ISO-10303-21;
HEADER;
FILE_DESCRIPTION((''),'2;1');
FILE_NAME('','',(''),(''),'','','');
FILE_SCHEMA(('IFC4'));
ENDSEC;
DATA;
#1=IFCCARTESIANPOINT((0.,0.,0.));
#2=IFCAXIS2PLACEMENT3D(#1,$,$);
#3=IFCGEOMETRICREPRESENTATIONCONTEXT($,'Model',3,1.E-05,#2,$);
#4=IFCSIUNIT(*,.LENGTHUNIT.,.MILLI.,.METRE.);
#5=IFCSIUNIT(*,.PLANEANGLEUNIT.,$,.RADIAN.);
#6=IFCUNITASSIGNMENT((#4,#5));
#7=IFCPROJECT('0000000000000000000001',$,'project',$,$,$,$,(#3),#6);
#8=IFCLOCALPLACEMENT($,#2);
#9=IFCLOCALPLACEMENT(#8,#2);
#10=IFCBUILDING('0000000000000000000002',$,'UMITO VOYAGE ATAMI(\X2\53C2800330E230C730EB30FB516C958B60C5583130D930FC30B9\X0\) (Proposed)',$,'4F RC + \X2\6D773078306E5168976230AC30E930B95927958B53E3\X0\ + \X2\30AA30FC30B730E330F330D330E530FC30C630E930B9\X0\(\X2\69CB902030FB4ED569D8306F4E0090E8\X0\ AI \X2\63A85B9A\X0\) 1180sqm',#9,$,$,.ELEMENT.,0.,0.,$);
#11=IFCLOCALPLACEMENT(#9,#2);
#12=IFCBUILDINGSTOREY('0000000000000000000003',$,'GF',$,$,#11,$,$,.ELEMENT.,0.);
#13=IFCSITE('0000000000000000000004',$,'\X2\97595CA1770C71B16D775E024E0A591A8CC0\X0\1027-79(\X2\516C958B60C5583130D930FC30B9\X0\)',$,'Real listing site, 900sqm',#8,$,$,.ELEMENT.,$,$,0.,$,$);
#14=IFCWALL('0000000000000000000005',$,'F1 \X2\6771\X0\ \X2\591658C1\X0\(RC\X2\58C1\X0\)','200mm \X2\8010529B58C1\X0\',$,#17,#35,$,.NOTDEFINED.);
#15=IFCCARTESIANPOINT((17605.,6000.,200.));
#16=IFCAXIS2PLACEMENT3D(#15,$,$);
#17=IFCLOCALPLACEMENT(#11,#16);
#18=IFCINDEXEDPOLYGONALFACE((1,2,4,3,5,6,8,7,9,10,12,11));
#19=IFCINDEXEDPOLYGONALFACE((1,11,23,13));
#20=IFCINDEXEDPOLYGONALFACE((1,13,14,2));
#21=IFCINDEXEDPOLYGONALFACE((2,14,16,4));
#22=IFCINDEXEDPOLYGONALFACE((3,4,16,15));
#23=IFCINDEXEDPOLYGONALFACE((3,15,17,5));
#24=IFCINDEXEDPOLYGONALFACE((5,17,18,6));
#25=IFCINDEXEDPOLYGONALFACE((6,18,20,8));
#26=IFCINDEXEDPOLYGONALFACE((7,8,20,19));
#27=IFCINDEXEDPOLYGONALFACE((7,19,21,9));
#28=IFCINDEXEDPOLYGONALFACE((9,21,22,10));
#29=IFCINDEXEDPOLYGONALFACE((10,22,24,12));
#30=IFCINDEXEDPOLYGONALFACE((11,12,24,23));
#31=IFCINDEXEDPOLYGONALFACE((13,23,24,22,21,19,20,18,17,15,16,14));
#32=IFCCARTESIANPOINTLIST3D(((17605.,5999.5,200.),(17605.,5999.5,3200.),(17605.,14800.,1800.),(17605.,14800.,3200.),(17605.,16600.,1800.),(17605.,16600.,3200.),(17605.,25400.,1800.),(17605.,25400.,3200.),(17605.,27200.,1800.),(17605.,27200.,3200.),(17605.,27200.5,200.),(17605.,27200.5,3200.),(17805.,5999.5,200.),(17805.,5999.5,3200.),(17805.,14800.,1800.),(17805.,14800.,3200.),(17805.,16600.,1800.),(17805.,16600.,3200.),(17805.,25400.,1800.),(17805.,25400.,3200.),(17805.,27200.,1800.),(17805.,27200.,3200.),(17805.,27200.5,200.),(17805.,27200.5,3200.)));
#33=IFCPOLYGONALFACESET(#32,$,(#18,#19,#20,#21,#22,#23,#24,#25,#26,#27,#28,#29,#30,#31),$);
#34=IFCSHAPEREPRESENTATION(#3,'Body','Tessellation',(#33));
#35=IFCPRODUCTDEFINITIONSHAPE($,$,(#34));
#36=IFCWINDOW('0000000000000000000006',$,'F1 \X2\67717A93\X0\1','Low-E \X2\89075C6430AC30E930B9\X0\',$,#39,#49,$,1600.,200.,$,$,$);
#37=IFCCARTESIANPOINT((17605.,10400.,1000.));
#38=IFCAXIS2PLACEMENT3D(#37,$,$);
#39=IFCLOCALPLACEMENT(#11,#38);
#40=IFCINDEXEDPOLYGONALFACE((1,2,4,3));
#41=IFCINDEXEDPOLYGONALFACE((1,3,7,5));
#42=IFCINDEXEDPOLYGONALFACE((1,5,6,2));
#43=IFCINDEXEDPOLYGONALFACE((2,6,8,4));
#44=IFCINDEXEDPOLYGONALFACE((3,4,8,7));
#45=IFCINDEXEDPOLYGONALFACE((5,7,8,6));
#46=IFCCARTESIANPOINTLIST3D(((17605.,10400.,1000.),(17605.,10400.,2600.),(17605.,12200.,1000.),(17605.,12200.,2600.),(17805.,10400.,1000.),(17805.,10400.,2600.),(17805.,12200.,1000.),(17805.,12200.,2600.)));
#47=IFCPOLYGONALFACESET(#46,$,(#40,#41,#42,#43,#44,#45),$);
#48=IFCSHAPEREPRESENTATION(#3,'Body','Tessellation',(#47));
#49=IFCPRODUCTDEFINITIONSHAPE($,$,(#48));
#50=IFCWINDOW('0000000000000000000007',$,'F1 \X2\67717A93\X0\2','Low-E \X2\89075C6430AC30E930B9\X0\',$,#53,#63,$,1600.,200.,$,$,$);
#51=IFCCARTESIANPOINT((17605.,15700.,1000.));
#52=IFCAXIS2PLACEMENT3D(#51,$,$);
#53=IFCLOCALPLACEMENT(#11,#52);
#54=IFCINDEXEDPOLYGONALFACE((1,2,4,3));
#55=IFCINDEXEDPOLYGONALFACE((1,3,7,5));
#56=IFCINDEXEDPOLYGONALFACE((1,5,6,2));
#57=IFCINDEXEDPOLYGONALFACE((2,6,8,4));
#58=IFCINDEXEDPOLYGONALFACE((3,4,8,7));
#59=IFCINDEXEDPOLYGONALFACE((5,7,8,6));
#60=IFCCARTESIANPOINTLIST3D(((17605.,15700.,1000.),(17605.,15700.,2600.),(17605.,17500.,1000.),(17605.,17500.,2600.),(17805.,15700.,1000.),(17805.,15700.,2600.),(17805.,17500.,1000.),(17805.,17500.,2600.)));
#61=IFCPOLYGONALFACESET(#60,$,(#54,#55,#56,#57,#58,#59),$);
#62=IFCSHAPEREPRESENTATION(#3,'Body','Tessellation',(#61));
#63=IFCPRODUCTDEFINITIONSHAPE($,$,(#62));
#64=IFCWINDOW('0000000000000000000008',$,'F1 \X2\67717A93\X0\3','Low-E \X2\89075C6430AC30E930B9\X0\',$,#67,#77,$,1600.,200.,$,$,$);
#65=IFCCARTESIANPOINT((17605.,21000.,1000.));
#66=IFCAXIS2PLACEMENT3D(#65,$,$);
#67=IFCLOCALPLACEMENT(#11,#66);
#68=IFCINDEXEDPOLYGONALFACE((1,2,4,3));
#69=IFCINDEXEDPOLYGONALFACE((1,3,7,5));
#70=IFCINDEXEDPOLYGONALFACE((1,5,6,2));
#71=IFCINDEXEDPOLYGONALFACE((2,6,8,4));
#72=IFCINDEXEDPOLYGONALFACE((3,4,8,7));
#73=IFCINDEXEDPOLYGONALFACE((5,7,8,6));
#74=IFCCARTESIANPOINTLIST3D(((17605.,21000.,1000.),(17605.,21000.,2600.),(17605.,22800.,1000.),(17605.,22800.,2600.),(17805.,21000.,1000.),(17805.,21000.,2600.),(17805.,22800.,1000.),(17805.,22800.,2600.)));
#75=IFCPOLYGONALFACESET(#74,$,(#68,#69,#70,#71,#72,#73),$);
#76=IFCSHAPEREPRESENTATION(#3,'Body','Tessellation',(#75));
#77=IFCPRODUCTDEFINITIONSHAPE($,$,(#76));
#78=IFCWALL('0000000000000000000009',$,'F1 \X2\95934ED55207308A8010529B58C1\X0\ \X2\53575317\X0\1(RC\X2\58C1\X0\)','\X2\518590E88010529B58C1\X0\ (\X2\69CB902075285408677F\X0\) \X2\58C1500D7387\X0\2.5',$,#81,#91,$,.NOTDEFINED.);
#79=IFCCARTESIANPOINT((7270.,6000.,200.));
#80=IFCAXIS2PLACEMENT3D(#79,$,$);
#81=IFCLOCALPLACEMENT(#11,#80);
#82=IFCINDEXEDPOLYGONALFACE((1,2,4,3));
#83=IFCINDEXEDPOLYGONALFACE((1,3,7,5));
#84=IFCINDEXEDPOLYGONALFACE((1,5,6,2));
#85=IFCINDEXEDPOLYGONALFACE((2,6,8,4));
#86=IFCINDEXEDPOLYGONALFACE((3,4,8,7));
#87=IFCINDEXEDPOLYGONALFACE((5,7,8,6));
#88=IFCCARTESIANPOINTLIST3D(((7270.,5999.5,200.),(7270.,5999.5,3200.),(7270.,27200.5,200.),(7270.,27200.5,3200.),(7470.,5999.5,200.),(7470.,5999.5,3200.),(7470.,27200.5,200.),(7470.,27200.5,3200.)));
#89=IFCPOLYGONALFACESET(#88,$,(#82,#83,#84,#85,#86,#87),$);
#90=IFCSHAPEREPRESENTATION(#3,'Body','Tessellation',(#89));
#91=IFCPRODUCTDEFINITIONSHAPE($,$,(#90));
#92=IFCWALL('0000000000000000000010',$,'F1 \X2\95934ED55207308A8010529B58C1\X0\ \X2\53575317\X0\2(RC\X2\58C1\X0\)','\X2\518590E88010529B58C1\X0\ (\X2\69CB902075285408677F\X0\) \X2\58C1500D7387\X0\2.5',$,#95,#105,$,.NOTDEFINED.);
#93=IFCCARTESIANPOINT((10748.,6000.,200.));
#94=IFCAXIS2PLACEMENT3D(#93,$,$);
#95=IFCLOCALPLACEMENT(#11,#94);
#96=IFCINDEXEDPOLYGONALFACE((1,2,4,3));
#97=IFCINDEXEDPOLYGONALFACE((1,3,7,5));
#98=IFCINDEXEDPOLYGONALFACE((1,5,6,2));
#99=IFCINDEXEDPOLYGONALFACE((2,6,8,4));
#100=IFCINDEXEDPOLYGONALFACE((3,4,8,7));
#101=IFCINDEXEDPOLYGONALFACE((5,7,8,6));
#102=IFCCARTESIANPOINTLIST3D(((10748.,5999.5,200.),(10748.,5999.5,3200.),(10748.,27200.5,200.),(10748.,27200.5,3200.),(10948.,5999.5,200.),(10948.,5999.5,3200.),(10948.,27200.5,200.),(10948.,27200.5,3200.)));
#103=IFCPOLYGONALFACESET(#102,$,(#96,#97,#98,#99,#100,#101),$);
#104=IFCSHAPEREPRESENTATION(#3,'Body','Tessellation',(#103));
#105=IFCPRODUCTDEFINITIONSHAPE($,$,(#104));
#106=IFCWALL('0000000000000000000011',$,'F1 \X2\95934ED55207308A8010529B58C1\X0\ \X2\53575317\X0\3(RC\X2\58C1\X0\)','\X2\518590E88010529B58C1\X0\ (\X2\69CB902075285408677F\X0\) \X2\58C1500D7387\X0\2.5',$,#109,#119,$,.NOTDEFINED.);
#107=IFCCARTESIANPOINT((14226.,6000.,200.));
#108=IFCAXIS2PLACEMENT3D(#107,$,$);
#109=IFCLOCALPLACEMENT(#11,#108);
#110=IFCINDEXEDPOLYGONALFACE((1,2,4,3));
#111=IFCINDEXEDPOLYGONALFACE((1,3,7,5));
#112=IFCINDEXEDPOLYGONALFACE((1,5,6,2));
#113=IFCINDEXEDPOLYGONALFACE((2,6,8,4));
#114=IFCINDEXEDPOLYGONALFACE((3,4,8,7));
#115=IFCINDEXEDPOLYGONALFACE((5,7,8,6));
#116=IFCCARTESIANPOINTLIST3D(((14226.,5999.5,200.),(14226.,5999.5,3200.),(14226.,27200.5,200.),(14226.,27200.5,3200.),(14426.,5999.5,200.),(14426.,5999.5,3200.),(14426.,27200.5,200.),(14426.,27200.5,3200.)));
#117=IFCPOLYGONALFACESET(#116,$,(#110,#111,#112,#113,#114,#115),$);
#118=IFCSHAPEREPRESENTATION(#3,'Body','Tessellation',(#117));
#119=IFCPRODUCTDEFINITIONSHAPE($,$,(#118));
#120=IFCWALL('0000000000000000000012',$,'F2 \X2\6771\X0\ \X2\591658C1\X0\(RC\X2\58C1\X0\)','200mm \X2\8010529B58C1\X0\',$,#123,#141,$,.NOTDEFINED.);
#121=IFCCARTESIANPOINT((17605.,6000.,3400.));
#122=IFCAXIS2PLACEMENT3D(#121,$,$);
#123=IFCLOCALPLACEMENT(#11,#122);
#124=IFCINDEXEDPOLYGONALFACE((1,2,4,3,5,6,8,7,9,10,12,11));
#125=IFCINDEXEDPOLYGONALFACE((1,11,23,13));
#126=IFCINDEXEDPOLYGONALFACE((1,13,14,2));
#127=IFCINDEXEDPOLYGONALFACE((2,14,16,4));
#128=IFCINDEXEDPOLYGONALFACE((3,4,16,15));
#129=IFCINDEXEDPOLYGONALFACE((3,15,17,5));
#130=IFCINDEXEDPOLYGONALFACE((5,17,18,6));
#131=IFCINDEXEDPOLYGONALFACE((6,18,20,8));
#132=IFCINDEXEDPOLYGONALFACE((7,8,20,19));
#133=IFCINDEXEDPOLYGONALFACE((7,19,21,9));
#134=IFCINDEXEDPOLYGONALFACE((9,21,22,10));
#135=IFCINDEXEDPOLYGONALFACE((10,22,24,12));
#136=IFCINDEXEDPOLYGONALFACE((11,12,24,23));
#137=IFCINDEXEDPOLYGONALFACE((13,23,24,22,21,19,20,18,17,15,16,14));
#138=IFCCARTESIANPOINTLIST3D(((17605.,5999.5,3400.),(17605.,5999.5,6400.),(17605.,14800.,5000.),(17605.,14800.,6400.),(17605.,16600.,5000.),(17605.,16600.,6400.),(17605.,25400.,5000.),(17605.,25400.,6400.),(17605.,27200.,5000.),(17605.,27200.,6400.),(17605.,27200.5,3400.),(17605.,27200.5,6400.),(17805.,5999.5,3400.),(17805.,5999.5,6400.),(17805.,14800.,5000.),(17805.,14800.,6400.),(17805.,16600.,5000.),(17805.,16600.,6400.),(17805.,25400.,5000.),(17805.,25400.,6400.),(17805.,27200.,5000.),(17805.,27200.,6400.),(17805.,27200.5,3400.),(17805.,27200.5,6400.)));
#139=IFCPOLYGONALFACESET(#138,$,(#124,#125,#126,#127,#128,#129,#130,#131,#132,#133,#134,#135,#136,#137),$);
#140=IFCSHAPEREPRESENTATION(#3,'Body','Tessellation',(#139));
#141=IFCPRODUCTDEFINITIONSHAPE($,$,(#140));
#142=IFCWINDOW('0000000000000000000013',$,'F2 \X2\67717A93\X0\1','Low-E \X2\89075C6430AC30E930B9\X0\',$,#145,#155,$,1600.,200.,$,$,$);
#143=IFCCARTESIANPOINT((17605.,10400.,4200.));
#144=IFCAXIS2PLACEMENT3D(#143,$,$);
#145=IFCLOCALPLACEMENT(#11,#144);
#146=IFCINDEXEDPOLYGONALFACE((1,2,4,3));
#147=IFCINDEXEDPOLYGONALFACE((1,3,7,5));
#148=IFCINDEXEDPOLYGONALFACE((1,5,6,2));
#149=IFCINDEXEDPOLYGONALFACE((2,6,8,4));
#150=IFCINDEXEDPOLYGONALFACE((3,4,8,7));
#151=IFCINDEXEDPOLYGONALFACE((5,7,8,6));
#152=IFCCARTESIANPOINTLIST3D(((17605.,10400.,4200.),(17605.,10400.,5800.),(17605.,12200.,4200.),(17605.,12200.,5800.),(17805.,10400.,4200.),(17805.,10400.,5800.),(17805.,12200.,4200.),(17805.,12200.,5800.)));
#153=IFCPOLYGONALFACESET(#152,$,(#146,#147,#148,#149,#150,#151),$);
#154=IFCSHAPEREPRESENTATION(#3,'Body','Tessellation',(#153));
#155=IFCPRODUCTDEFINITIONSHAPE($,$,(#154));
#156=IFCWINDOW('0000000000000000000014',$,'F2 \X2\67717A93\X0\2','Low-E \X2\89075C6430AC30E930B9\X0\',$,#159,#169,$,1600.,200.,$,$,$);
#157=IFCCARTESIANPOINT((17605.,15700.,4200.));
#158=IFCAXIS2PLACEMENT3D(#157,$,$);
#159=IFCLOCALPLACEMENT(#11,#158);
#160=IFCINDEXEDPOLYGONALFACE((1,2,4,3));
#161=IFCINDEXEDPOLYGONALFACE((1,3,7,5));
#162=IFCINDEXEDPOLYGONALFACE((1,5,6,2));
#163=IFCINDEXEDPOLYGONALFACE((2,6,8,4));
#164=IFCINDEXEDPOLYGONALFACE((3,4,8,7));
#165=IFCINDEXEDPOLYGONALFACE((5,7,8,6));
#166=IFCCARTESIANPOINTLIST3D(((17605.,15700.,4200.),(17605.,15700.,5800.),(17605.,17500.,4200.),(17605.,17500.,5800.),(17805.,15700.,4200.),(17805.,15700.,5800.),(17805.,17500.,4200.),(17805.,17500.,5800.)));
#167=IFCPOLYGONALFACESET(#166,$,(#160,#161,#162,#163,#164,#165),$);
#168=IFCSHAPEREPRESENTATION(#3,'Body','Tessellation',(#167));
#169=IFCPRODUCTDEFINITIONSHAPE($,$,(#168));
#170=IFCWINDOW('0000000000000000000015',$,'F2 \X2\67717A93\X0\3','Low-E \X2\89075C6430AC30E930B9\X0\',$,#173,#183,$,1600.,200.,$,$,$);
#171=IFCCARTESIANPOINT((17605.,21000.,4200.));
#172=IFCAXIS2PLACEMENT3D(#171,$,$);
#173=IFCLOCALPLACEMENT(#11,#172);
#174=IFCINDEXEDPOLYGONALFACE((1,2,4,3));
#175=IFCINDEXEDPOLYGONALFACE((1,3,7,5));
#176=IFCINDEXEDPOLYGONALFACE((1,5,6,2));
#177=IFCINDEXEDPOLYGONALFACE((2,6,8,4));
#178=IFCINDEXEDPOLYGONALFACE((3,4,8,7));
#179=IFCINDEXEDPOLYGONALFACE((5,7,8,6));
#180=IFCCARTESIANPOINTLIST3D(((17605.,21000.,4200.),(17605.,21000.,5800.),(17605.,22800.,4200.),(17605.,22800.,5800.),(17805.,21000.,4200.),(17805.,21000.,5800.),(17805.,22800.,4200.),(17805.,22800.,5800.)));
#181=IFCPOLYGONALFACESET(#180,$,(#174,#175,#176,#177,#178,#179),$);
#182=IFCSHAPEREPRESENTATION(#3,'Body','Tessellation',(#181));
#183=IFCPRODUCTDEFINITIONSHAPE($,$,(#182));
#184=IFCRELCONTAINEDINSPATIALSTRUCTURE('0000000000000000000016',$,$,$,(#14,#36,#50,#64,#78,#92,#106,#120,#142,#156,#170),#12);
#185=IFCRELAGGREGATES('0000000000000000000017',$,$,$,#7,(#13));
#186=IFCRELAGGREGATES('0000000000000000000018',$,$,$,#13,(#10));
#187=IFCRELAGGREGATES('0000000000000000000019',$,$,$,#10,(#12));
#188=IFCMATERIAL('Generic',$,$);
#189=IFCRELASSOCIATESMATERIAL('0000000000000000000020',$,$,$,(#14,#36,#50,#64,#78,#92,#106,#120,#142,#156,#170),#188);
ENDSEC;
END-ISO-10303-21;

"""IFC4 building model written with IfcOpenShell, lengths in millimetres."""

from ifc_helpers import new_model, si_unit, frame, frame_2d, origin, place, context, project, spatial, rectangle, extrude, material, element, fill, save


model = new_model("IFC4")

# Units and contexts
model_context = context("Model", 3, precision=1e-05, world=origin())
ifc_project = project(units=[si_unit("LENGTHUNIT", "METRE", prefix="MILLI"), si_unit("PLANEANGLEUNIT", "RADIAN")], contexts=[model_context])

# Site, building, storey
site_placement = place(None, origin())
site = spatial("IfcSite", under=ifc_project, at=site_placement, Name="静岡県熱海市上多賀1027-79(公開情報ベース)", ObjectType="Real listing site, 900sqm", CompositionType="ELEMENT", RefElevation=0.0)
building_placement = place(site_placement, origin())
building = spatial("IfcBuilding", under=site, at=building_placement, Name="UMITO VOYAGE ATAMI(参考モデル・公開情報ベース) (Proposed)", ObjectType="4F RC + 海への全面ガラス大開口 + オーシャンビューテラス(構造・仕様は一部 AI 推定) 1180sqm", CompositionType="ELEMENT", ElevationOfRefHeight=0.0, ElevationOfTerrain=0.0)
storey_placement = place(building_placement, origin())
storey = spatial("IfcBuildingStorey", under=building, at=storey_placement, Name="GF", CompositionType="ELEMENT", Elevation=0.0)

# Wall, openings, windows
ifc_material = material(Name="Generic")
wall_1_placement = place(storey_placement, frame((17605.0, 6000.0, 200.0)))
wall_1 = element("IfcWall", 1, at=wall_1_placement, inside=storey, material=ifc_material, Name="F1 東 外壁(RC壁)", Description="200mm 耐力壁", PredefinedType="NOTDEFINED", context=model_context, shape_type="SweptSolid", body=[
    extrude(rectangle(XDim=200.0, YDim=21201.0, at=frame_2d((100.0, 10600.0))), frame((17605.0, 6000.0, 200.0)), (0.0, 0.0, 1.0), 3000.0),
])
opening_1_placement = place(storey_placement, frame((17605.0, 10400.0, 1000.0)))
opening_1 = element("IfcOpeningElement", 2, at=opening_1_placement, cuts=wall_1, PredefinedType="NOTDEFINED", context=model_context, shape_type="SweptSolid", body=[
    extrude(rectangle(XDim=200.0, YDim=1800.0, at=frame_2d((100.0, 900.0))), frame((17605.0, 10400.0, 1000.0)), (0.0, 0.0, 1.0), 1600.0),
])
opening_2_placement = place(storey_placement, frame((17605.0, 15700.0, 1000.0)))
opening_2 = element("IfcOpeningElement", 3, at=opening_2_placement, cuts=wall_1, PredefinedType="NOTDEFINED", context=model_context, shape_type="SweptSolid", body=[
    extrude(rectangle(XDim=200.0, YDim=1800.0, at=frame_2d((100.0, 900.0))), frame((17605.0, 15700.0, 1000.0)), (0.0, 0.0, 1.0), 1600.0),
])
opening_3_placement = place(storey_placement, frame((17605.0, 21000.0, 1000.0)))
opening_3 = element("IfcOpeningElement", 4, at=opening_3_placement, cuts=wall_1, PredefinedType="NOTDEFINED", context=model_context, shape_type="SweptSolid", body=[
    extrude(rectangle(XDim=200.0, YDim=1800.0, at=frame_2d((100.0, 900.0))), frame((17605.0, 21000.0, 1000.0)), (0.0, 0.0, 1.0), 1600.0),
])
window_1_placement = place(storey_placement, frame((17605.0, 10400.0, 1000.0)))
window_1 = element("IfcWindow", 5, at=window_1_placement, inside=storey, material=ifc_material, Name="F1 東窓1", Description="Low-E 複層ガラス", OverallHeight=1600.0, OverallWidth=200.0, context=model_context, shape_type="SweptSolid", body=[
    extrude(rectangle(XDim=200.0, YDim=1800.0, at=frame_2d((100.0, 900.0))), frame((17605.0, 10400.0, 1000.0)), (0.0, 0.0, 1.0), 1600.0),
])
fill(opening_1, window_1)
window_2_placement = place(storey_placement, frame((17605.0, 15700.0, 1000.0)))
window_2 = element("IfcWindow", 6, at=window_2_placement, inside=storey, material=ifc_material, Name="F1 東窓2", Description="Low-E 複層ガラス", OverallHeight=1600.0, OverallWidth=200.0, context=model_context, shape_type="SweptSolid", body=[
    extrude(rectangle(XDim=200.0, YDim=1800.0, at=frame_2d((100.0, 900.0))), frame((17605.0, 15700.0, 1000.0)), (0.0, 0.0, 1.0), 1600.0),
])
fill(opening_2, window_2)
window_3_placement = place(storey_placement, frame((17605.0, 21000.0, 1000.0)))
window_3 = element("IfcWindow", 7, at=window_3_placement, inside=storey, material=ifc_material, Name="F1 東窓3", Description="Low-E 複層ガラス", OverallHeight=1600.0, OverallWidth=200.0, context=model_context, shape_type="SweptSolid", body=[
    extrude(rectangle(XDim=200.0, YDim=1800.0, at=frame_2d((100.0, 900.0))), frame((17605.0, 21000.0, 1000.0)), (0.0, 0.0, 1.0), 1600.0),
])
fill(opening_3, window_3)

# Walls
wall_2_placement = place(storey_placement, frame((7270.0, 6000.0, 200.0)))
element("IfcWall", 8, at=wall_2_placement, inside=storey, material=ifc_material, Name="F1 間仕切り耐力壁 南北1(RC壁)", Description="内部耐力壁 (構造用合板) 壁倍率2.5", PredefinedType="NOTDEFINED", context=model_context, shape_type="SweptSolid", body=[
    extrude(rectangle(XDim=200.0, YDim=21201.0, at=frame_2d((100.0, 10600.0))), frame((7270.0, 6000.0, 200.0)), (0.0, 0.0, 1.0), 3000.0),
])
wall_3_placement = place(storey_placement, frame((10748.0, 6000.0, 200.0)))
element("IfcWall", 9, at=wall_3_placement, inside=storey, material=ifc_material, Name="F1 間仕切り耐力壁 南北2(RC壁)", Description="内部耐力壁 (構造用合板) 壁倍率2.5", PredefinedType="NOTDEFINED", context=model_context, shape_type="SweptSolid", body=[
    extrude(rectangle(XDim=200.0, YDim=21201.0, at=frame_2d((100.0, 10600.0))), frame((10748.0, 6000.0, 200.0)), (0.0, 0.0, 1.0), 3000.0),
])
wall_4_placement = place(storey_placement, frame((14226.0, 6000.0, 200.0)))
element("IfcWall", 10, at=wall_4_placement, inside=storey, material=ifc_material, Name="F1 間仕切り耐力壁 南北3(RC壁)", Description="内部耐力壁 (構造用合板) 壁倍率2.5", PredefinedType="NOTDEFINED", context=model_context, shape_type="SweptSolid", body=[
    extrude(rectangle(XDim=200.0, YDim=21201.0, at=frame_2d((100.0, 10600.0))), frame((14226.0, 6000.0, 200.0)), (0.0, 0.0, 1.0), 3000.0),
])

# Wall, openings, windows
wall_5_placement = place(storey_placement, frame((17605.0, 6000.0, 3400.0)))
wall_5 = element("IfcWall", 11, at=wall_5_placement, inside=storey, material=ifc_material, Name="F2 東 外壁(RC壁)", Description="200mm 耐力壁", PredefinedType="NOTDEFINED", context=model_context, shape_type="SweptSolid", body=[
    extrude(rectangle(XDim=200.0, YDim=21201.0, at=frame_2d((100.0, 10600.0))), frame((17605.0, 6000.0, 3400.0)), (0.0, 0.0, 1.0), 3000.0),
])
opening_4_placement = place(storey_placement, frame((17605.0, 10400.0, 4200.0)))
opening_4 = element("IfcOpeningElement", 12, at=opening_4_placement, cuts=wall_5, PredefinedType="NOTDEFINED", context=model_context, shape_type="SweptSolid", body=[
    extrude(rectangle(XDim=200.0, YDim=1800.0, at=frame_2d((100.0, 900.0))), frame((17605.0, 10400.0, 4200.0)), (0.0, 0.0, 1.0), 1600.0),
])
opening_5_placement = place(storey_placement, frame((17605.0, 15700.0, 4200.0)))
opening_5 = element("IfcOpeningElement", 13, at=opening_5_placement, cuts=wall_5, PredefinedType="NOTDEFINED", context=model_context, shape_type="SweptSolid", body=[
    extrude(rectangle(XDim=200.0, YDim=1800.0, at=frame_2d((100.0, 900.0))), frame((17605.0, 15700.0, 4200.0)), (0.0, 0.0, 1.0), 1600.0),
])
opening_6_placement = place(storey_placement, frame((17605.0, 21000.0, 4200.0)))
opening_6 = element("IfcOpeningElement", 14, at=opening_6_placement, cuts=wall_5, PredefinedType="NOTDEFINED", context=model_context, shape_type="SweptSolid", body=[
    extrude(rectangle(XDim=200.0, YDim=1800.0, at=frame_2d((100.0, 900.0))), frame((17605.0, 21000.0, 4200.0)), (0.0, 0.0, 1.0), 1600.0),
])
window_4_placement = place(storey_placement, frame((17605.0, 10400.0, 4200.0)))
window_4 = element("IfcWindow", 15, at=window_4_placement, inside=storey, material=ifc_material, Name="F2 東窓1", Description="Low-E 複層ガラス", OverallHeight=1600.0, OverallWidth=200.0, context=model_context, shape_type="SweptSolid", body=[
    extrude(rectangle(XDim=200.0, YDim=1800.0, at=frame_2d((100.0, 900.0))), frame((17605.0, 10400.0, 4200.0)), (0.0, 0.0, 1.0), 1600.0),
])
fill(opening_4, window_4)
window_5_placement = place(storey_placement, frame((17605.0, 15700.0, 4200.0)))
window_5 = element("IfcWindow", 16, at=window_5_placement, inside=storey, material=ifc_material, Name="F2 東窓2", Description="Low-E 複層ガラス", OverallHeight=1600.0, OverallWidth=200.0, context=model_context, shape_type="SweptSolid", body=[
    extrude(rectangle(XDim=200.0, YDim=1800.0, at=frame_2d((100.0, 900.0))), frame((17605.0, 15700.0, 4200.0)), (0.0, 0.0, 1.0), 1600.0),
])
fill(opening_5, window_5)
window_6_placement = place(storey_placement, frame((17605.0, 21000.0, 4200.0)))
window_6 = element("IfcWindow", 17, at=window_6_placement, inside=storey, material=ifc_material, Name="F2 東窓3", Description="Low-E 複層ガラス", OverallHeight=1600.0, OverallWidth=200.0, context=model_context, shape_type="SweptSolid", body=[
    extrude(rectangle(XDim=200.0, YDim=1800.0, at=frame_2d((100.0, 900.0))), frame((17605.0, 21000.0, 4200.0)), (0.0, 0.0, 1.0), 1600.0),
])
fill(opening_6, window_6)

save(model, "model.ifc")
